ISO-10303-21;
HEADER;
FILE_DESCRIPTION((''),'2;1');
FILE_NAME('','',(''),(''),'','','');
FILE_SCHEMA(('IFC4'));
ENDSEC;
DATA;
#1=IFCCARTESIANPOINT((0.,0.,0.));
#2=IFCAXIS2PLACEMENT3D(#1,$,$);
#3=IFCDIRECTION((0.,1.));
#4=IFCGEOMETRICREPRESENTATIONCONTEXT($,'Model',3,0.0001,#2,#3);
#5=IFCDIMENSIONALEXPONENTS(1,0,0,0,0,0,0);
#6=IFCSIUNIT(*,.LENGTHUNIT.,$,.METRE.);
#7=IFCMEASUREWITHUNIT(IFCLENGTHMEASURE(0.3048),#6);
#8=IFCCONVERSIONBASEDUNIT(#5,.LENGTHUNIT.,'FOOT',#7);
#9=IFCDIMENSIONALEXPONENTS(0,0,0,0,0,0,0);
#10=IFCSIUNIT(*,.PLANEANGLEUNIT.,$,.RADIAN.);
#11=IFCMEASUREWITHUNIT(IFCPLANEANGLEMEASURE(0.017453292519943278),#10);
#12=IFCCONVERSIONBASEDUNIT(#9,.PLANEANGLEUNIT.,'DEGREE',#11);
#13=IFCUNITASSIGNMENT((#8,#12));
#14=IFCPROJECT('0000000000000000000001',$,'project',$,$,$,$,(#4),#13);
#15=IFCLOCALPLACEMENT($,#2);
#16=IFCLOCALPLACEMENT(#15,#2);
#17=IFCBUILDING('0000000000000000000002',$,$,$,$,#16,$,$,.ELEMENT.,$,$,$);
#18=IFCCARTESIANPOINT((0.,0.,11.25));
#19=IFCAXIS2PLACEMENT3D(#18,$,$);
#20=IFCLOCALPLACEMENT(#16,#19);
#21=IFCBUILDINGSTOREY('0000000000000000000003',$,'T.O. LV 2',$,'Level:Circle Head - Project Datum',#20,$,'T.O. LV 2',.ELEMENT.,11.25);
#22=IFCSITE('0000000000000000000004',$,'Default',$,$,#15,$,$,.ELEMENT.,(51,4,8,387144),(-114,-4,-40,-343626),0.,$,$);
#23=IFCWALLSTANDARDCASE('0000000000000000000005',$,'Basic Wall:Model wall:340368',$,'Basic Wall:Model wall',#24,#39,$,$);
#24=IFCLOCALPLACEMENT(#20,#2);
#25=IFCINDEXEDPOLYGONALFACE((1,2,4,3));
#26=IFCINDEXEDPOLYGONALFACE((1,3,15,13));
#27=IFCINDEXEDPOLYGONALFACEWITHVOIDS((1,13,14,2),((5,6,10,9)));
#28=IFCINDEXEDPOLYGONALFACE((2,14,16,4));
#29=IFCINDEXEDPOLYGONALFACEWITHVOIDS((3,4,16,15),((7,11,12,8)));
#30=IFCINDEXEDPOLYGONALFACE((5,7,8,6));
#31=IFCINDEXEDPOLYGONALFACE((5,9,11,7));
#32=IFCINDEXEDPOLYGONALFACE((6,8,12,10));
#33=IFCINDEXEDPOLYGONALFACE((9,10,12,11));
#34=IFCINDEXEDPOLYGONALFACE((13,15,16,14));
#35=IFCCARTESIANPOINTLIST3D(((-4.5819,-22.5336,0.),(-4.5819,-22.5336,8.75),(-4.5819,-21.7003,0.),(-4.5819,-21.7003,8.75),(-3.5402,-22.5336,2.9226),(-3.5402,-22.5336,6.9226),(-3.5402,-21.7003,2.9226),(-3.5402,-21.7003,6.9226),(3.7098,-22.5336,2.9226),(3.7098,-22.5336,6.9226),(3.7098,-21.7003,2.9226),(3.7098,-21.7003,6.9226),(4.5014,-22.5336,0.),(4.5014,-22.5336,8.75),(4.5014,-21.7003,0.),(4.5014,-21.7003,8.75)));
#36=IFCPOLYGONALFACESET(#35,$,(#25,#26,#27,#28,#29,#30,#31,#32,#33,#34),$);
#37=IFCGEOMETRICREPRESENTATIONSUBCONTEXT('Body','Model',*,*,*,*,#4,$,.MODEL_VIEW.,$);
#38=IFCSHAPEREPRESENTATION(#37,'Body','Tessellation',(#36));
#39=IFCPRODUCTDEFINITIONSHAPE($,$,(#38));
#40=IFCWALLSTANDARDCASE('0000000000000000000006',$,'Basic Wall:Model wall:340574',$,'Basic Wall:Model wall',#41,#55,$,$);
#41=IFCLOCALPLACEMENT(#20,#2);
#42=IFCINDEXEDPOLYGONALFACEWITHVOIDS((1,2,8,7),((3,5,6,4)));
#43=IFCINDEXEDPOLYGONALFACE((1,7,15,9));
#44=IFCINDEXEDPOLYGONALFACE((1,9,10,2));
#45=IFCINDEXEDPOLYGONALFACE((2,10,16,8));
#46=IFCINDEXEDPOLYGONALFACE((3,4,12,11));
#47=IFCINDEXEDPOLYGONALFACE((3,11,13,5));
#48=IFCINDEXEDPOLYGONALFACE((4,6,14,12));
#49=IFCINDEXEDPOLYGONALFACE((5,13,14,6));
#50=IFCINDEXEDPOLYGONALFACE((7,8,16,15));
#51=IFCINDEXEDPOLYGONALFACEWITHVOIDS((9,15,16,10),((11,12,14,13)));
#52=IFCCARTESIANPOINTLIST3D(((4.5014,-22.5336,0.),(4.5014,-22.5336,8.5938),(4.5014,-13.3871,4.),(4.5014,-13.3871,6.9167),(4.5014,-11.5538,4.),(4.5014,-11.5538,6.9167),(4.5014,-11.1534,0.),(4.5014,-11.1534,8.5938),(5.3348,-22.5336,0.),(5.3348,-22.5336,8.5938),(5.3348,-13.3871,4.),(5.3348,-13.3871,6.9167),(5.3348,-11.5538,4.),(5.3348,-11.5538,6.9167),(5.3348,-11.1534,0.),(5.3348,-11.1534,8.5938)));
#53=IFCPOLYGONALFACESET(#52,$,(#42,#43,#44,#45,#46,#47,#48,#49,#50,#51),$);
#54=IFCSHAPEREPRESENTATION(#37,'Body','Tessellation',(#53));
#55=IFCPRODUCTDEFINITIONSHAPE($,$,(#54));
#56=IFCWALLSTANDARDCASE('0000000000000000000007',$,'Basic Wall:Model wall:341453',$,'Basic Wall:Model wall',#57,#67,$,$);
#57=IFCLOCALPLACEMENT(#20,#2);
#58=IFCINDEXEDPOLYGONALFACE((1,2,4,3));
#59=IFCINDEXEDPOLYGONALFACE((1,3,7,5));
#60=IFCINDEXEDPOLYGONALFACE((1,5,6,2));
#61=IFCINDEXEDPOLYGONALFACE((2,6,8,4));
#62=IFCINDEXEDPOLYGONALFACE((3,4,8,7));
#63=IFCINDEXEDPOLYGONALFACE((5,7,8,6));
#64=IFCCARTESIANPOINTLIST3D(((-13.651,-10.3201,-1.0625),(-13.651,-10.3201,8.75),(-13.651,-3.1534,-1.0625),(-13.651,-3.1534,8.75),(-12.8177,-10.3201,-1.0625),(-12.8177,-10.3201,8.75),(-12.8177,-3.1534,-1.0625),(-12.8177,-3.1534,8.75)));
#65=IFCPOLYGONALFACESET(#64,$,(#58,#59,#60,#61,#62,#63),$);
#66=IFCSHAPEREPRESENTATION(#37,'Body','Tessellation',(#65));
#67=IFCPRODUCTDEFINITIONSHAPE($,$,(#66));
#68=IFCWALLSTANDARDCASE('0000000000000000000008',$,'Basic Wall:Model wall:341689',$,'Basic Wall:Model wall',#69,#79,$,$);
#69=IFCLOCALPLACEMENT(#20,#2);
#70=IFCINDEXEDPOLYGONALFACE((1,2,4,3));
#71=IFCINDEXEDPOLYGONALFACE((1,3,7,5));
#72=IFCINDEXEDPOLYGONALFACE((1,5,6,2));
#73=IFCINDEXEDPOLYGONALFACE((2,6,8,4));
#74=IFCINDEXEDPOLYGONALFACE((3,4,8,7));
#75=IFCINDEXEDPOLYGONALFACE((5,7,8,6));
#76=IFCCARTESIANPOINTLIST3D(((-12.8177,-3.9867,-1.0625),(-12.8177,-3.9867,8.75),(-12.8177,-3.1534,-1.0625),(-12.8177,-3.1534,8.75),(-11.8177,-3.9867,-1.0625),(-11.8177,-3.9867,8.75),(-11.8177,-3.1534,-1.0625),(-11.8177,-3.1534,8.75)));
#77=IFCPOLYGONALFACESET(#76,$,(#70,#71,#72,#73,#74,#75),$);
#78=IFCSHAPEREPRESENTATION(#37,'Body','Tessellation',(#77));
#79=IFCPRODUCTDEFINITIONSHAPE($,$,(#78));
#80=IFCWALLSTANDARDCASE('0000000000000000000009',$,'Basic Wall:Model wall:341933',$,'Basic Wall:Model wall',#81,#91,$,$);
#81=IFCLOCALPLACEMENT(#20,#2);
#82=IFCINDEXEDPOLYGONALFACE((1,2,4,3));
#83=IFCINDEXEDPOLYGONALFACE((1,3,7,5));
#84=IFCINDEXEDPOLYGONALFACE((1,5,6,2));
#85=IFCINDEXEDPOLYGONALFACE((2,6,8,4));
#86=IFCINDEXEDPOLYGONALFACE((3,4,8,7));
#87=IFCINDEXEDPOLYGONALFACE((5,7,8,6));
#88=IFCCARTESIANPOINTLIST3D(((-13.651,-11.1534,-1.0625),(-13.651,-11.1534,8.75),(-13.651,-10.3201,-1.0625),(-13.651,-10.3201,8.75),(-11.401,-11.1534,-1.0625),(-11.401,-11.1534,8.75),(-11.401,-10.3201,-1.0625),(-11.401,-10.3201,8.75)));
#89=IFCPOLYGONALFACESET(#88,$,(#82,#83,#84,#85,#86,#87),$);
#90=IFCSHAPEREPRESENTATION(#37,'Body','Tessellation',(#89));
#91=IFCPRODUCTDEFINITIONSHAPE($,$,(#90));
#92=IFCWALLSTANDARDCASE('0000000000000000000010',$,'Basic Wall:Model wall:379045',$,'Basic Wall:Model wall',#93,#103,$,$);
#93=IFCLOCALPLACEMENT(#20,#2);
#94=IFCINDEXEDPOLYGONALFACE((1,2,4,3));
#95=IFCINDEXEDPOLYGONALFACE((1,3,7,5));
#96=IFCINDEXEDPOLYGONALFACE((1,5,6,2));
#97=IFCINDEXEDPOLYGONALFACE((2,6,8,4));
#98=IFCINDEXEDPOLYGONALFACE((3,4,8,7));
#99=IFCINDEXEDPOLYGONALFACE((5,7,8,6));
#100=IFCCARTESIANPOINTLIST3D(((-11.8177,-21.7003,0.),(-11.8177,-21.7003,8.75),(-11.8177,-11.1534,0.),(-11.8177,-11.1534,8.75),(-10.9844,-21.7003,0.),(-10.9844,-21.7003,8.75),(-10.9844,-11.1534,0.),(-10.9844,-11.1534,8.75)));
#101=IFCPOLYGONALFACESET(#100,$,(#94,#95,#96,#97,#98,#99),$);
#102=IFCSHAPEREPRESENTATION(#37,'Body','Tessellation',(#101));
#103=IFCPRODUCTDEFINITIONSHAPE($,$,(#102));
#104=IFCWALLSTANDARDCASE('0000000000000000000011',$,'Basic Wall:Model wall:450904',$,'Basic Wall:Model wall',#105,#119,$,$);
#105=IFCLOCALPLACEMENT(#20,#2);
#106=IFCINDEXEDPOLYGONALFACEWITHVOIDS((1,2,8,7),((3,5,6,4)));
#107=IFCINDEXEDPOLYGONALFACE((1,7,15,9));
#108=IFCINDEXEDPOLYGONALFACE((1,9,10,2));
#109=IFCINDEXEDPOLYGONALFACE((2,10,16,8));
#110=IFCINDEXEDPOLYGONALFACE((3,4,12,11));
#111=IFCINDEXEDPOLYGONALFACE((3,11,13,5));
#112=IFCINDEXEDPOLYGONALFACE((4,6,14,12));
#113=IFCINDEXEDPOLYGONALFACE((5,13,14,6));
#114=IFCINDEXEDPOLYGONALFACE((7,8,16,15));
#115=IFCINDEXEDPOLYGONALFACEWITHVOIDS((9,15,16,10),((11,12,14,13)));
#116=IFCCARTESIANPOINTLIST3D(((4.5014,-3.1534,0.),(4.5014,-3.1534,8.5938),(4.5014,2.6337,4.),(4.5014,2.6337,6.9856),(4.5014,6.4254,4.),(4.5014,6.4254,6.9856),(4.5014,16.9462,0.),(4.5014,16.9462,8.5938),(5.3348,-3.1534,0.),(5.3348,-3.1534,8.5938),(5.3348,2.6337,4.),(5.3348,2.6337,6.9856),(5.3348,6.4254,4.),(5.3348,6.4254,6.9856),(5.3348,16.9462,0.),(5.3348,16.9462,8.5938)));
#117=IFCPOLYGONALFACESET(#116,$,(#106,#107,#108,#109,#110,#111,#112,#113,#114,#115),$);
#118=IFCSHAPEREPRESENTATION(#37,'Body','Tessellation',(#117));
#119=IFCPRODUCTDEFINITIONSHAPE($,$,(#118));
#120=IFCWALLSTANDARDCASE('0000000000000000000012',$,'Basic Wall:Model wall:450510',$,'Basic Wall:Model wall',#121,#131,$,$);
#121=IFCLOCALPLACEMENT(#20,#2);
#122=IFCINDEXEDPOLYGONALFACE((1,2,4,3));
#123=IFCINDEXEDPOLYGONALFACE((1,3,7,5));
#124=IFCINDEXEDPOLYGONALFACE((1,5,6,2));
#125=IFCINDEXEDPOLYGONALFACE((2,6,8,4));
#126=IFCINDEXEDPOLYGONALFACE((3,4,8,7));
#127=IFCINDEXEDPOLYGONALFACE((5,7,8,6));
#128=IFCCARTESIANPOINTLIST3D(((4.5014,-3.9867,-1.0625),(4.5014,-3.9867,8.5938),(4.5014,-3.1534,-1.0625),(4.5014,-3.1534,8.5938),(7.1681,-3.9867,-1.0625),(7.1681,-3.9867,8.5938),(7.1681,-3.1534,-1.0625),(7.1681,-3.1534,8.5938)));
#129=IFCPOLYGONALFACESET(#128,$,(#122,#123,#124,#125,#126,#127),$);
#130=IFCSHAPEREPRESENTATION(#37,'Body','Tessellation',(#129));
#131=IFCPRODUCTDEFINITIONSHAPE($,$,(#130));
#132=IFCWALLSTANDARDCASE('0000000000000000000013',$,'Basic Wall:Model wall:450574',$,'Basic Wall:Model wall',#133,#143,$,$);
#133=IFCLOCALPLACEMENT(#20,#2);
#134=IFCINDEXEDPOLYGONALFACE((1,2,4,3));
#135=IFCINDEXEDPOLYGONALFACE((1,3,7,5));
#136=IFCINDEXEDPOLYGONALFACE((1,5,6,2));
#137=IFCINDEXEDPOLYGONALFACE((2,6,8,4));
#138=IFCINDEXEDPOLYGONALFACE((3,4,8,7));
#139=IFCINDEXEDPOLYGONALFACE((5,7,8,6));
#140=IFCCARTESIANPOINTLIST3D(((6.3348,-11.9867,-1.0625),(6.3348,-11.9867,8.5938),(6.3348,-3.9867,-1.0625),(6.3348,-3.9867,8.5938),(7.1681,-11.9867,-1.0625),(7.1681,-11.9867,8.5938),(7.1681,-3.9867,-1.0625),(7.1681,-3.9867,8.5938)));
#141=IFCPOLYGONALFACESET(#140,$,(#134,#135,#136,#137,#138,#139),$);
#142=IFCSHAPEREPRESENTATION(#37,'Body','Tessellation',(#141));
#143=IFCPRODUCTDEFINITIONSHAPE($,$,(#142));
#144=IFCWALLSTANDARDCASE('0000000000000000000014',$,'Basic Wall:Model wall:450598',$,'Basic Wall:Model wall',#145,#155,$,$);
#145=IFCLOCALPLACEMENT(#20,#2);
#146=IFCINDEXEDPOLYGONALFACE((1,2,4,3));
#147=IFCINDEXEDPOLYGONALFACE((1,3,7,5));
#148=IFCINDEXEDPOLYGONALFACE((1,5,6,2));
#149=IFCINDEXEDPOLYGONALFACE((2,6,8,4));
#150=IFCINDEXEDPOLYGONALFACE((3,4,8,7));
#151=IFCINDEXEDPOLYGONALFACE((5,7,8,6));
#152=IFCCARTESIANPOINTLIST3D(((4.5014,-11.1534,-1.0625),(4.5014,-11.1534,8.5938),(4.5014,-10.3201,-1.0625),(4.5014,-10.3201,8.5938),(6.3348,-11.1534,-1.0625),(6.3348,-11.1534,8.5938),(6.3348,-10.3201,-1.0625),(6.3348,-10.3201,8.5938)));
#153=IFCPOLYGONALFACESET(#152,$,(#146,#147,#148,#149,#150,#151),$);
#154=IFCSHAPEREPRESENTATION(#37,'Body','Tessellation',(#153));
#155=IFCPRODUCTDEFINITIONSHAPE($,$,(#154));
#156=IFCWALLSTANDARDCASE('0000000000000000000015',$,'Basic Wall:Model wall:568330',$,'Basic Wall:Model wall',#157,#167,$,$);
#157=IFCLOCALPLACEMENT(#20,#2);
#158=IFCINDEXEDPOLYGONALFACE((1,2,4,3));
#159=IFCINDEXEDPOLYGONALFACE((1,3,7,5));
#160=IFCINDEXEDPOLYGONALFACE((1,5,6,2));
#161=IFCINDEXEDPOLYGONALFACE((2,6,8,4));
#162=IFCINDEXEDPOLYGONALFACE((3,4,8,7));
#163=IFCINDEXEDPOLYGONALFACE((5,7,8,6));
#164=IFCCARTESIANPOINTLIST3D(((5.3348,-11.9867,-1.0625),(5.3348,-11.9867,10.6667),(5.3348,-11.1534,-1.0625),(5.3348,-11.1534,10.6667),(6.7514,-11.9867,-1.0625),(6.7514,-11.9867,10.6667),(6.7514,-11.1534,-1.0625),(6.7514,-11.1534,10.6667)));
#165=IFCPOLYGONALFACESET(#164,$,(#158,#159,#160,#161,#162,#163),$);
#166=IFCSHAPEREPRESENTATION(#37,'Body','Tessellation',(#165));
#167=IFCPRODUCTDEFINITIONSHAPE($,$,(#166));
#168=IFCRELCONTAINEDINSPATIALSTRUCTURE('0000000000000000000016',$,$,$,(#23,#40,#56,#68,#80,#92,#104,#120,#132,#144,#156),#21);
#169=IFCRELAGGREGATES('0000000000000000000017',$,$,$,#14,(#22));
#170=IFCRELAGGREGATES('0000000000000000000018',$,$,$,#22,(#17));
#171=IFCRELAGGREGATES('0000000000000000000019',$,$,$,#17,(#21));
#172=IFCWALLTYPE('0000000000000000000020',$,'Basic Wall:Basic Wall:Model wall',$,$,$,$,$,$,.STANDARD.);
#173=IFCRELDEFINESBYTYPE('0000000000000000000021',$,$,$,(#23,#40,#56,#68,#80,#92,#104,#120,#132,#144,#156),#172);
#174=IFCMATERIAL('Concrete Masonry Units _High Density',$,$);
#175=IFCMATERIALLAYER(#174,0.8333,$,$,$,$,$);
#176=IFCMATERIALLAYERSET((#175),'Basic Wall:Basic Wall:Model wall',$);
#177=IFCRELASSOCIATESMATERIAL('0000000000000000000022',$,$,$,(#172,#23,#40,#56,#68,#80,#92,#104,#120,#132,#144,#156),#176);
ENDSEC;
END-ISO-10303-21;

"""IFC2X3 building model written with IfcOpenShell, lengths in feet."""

from ifc_helpers import new_model, entity, si_unit, converted_unit, direction, frame, frame_2d, origin, place, context, subcontext, project, spatial, rectangle, extrude, material, layer, layer_set, layer_usage, type_object, element, save


model = new_model("IFC2X3")

# Units and contexts
model_context = context("Model", 3, precision=0.0001, world=origin(), true_north=direction((0.0, 1.0)))
body_context = subcontext(model_context, "Body", "Model", "MODEL_VIEW")
ifc_project = project(units=[converted_unit("LENGTHUNIT", "FOOT", entity("IfcLengthMeasure", 0.3048), si_unit("LENGTHUNIT", "METRE"), dimensions=[1, 0, 0, 0, 0, 0, 0]), converted_unit("PLANEANGLEUNIT", "DEGREE", entity("IfcPlaneAngleMeasure", 0.017453292519943278), si_unit("PLANEANGLEUNIT", "RADIAN"), dimensions=[0, 0, 0, 0, 0, 0, 0])], contexts=[model_context])

# Site, building, storey
site_placement = place(None, origin())
site = spatial("IfcSite", under=ifc_project, at=site_placement, Name="Default", CompositionType="ELEMENT", RefLatitude=(51, 4, 8, 387144), RefLongitude=(-114, -4, -40, -343626), RefElevation=0.0)
building_placement = place(site_placement, origin())
building = spatial("IfcBuilding", under=site, at=building_placement, CompositionType="ELEMENT")
storey_placement = place(building_placement, frame((0.0, 0.0, 11.25)))
storey = spatial("IfcBuildingStorey", under=building, at=storey_placement, Name="T.O. LV 2", ObjectType="Level:Circle Head - Project Datum", LongName="T.O. LV 2", CompositionType="ELEMENT", Elevation=11.25)

# Walls, openings
ifc_material_1 = material(Name="Concrete Masonry Units _High Density")
ifc_layer_1 = layer(ifc_material_1, 0.8333)
ifc_layer_set_1 = layer_set([ifc_layer_1], Name="Basic Wall:Basic Wall:Model wall")
ifc_layer_usage_1 = layer_usage(ifc_layer_set_1, "AXIS2", "NEGATIVE", 0.4167)
wall_type_1 = type_object("IfcWallType", Name="Basic Wall:Basic Wall:Model wall", PredefinedType="STANDARD", material=ifc_layer_set_1)
wall_1_placement = place(storey_placement, frame((4.5014, -22.117, 0.0), z_axis=(0.0, 0.0, 1.0), x_axis=(-1.0, 0.0, 0.0)))
wall_1 = element("IfcWallStandardCase", 1, at=wall_1_placement, inside=storey, type_object=wall_type_1, material=ifc_layer_usage_1, Name="Basic Wall:Model wall:340368", ObjectType="Basic Wall:Model wall", context=body_context, shape_type="SweptSolid", body=[
    extrude(rectangle(XDim=9.0833, YDim=0.8333, at=frame_2d((4.5417, 0.0), x_axis=(-1.0, 0.0))), origin(), (0.0, 0.0, 1.0), 8.75),
])
opening_1_placement = place(wall_1_placement, frame((4.5014, -22.117, 0.0), z_axis=(0.0, 0.0, 1.0), x_axis=(-1.0, 0.0, 0.0)))
element("IfcOpeningElement", 2, at=opening_1_placement, cuts=wall_1, ObjectType="Opening", context=body_context, shape_type="SweptSolid", body=[
    extrude(rectangle(XDim=4.0, YDim=7.25, at=frame_2d((0.0, 0.0), x_axis=(0.0, 1.0))), frame((0.0848, -21.692, 4.9226), z_axis=(0.0, -1.0, 0.0), x_axis=(1.0, 0.0, 0.0)), (0.0, 0.0, 1.0), 0.85),
])
ifc_layer_usage_2 = layer_usage(ifc_layer_set_1, "AXIS2", "NEGATIVE", 0.4167)
wall_2_placement = place(storey_placement, frame((4.9181, -22.5336, 0.0), z_axis=(0.0, 0.0, 1.0), x_axis=(0.0, 1.0, 0.0)))
wall_2 = element("IfcWallStandardCase", 3, at=wall_2_placement, inside=storey, type_object=wall_type_1, material=ifc_layer_usage_2, Name="Basic Wall:Model wall:340574", ObjectType="Basic Wall:Model wall", context=body_context, shape_type="SweptSolid", body=[
    extrude(rectangle(XDim=11.3802, YDim=0.8333, at=frame_2d((5.6901, 0.0), x_axis=(-1.0, 0.0))), origin(), (0.0, 0.0, 1.0), 8.5938),
])
opening_2_placement = place(wall_2_placement, frame((22.5336, 4.9181, 0.0), z_axis=(0.0, 0.0, 1.0), x_axis=(0.0, -1.0, 0.0)))
element("IfcOpeningElement", 4, at=opening_2_placement, cuts=wall_2, ObjectType="Opening", context=body_context, shape_type="SweptSolid", body=[
    extrude(rectangle(XDim=2.9167, YDim=1.8333, at=frame_2d((0.0, 0.0), x_axis=(1.0, 0.0))), frame((5.3431, -12.4705, 5.4583), z_axis=(-1.0, 0.0, 0.0), x_axis=(0.0, 0.0, 1.0)), (0.0, 0.0, 1.0), 0.85),
])

# Walls
ifc_layer_usage_3 = layer_usage(ifc_layer_set_1, "AXIS2", "NEGATIVE", 0.4167)
wall_3_placement = place(storey_placement, frame((-13.2344, -3.1534, -1.0625), z_axis=(0.0, 0.0, 1.0), x_axis=(0.0, -1.0, 0.0)))
element("IfcWallStandardCase", 5, at=wall_3_placement, inside=storey, type_object=wall_type_1, material=ifc_layer_usage_3, Name="Basic Wall:Model wall:341453", ObjectType="Basic Wall:Model wall", context=body_context, shape_type="SweptSolid", body=[
    extrude(rectangle(XDim=7.1667, YDim=0.8333, at=frame_2d((3.5833, 0.0), x_axis=(-1.0, 0.0))), origin(), (0.0, 0.0, 1.0), 9.8125),
])
ifc_layer_usage_4 = layer_usage(ifc_layer_set_1, "AXIS2", "NEGATIVE", 0.4167)
wall_4_placement = place(storey_placement, frame((-12.8177, -3.5701, -1.0625)))
element("IfcWallStandardCase", 6, at=wall_4_placement, inside=storey, type_object=wall_type_1, material=ifc_layer_usage_4, Name="Basic Wall:Model wall:341689", ObjectType="Basic Wall:Model wall", context=body_context, shape_type="SweptSolid", body=[
    extrude(rectangle(XDim=1.0, YDim=0.8333, at=frame_2d((0.5, 0.0), x_axis=(-1.0, 0.0))), origin(), (0.0, 0.0, 1.0), 9.8125),
])
ifc_layer_usage_5 = layer_usage(ifc_layer_set_1, "AXIS2", "NEGATIVE", 0.4167)
wall_5_placement = place(storey_placement, frame((-13.651, -10.7367, -1.0625)))
element("IfcWallStandardCase", 7, at=wall_5_placement, inside=storey, type_object=wall_type_1, material=ifc_layer_usage_5, Name="Basic Wall:Model wall:341933", ObjectType="Basic Wall:Model wall", context=body_context, shape_type="SweptSolid", body=[
    extrude(rectangle(XDim=2.25, YDim=0.8333, at=frame_2d((1.125, 0.0), x_axis=(-1.0, 0.0))), origin(), (0.0, 0.0, 1.0), 9.8125),
])
ifc_layer_usage_6 = layer_usage(ifc_layer_set_1, "AXIS2", "NEGATIVE", 0.4167)
wall_6_placement = place(storey_placement, frame((-11.401, -11.1534, 0.0), z_axis=(0.0, 0.0, 1.0), x_axis=(0.0, -1.0, 0.0)))
element("IfcWallStandardCase", 8, at=wall_6_placement, inside=storey, type_object=wall_type_1, material=ifc_layer_usage_6, Name="Basic Wall:Model wall:379045", ObjectType="Basic Wall:Model wall", context=body_context, shape_type="SweptSolid", body=[
    extrude(rectangle(XDim=10.5469, YDim=0.8333, at=frame_2d((5.2734, 0.0), x_axis=(-1.0, 0.0))), origin(), (0.0, 0.0, 1.0), 8.75),
])

# Wall, opening
ifc_layer_usage_7 = layer_usage(ifc_layer_set_1, "AXIS2", "NEGATIVE", 0.4167)
wall_7_placement = place(storey_placement, frame((4.9181, -3.1534, 0.0), z_axis=(0.0, 0.0, 1.0), x_axis=(0.0, 1.0, 0.0)))
wall_7 = element("IfcWallStandardCase", 9, at=wall_7_placement, inside=storey, type_object=wall_type_1, material=ifc_layer_usage_7, Name="Basic Wall:Model wall:450904", ObjectType="Basic Wall:Model wall", context=body_context, shape_type="SweptSolid", body=[
    extrude(rectangle(XDim=20.0996, YDim=0.8333, at=frame_2d((10.0498, 0.0), x_axis=(-1.0, 0.0))), origin(), (0.0, 0.0, 1.0), 8.5938),
])
opening_3_placement = place(wall_7_placement, frame((3.1534, 4.9181, 0.0), z_axis=(0.0, 0.0, 1.0), x_axis=(0.0, -1.0, 0.0)))
element("IfcOpeningElement", 10, at=opening_3_placement, cuts=wall_7, ObjectType="Opening", context=body_context, shape_type="SweptSolid", body=[
    extrude(rectangle(XDim=2.9856, YDim=3.7917, at=frame_2d((0.0, 0.0), x_axis=(1.0, 0.0))), frame((5.3431, 4.5295, 5.4928), z_axis=(-1.0, 0.0, 0.0), x_axis=(0.0, 0.0, 1.0)), (0.0, 0.0, 1.0), 0.85),
])

# Walls
ifc_layer_usage_8 = layer_usage(ifc_layer_set_1, "AXIS2", "NEGATIVE", 0.4167)
wall_8_placement = place(storey_placement, frame((4.5014, -3.5701, -1.0625)))
element("IfcWallStandardCase", 11, at=wall_8_placement, inside=storey, type_object=wall_type_1, material=ifc_layer_usage_8, Name="Basic Wall:Model wall:450510", ObjectType="Basic Wall:Model wall", context=body_context, shape_type="SweptSolid", body=[
    extrude(rectangle(XDim=2.6667, YDim=0.8333, at=frame_2d((1.3333, 0.0), x_axis=(-1.0, 0.0))), origin(), (0.0, 0.0, 1.0), 9.6563),
])
ifc_layer_usage_9 = layer_usage(ifc_layer_set_1, "AXIS2", "NEGATIVE", 0.4167)
wall_9_placement = place(storey_placement, frame((6.7514, -3.9867, -1.0625), z_axis=(0.0, 0.0, 1.0), x_axis=(0.0, -1.0, 0.0)))
element("IfcWallStandardCase", 12, at=wall_9_placement, inside=storey, type_object=wall_type_1, material=ifc_layer_usage_9, Name="Basic Wall:Model wall:450574", ObjectType="Basic Wall:Model wall", context=body_context, shape_type="SweptSolid", body=[
    extrude(rectangle(XDim=8.0, YDim=0.8333, at=frame_2d((4.0, 0.0), x_axis=(-1.0, 0.0))), origin(), (0.0, 0.0, 1.0), 9.6563),
])
ifc_layer_usage_10 = layer_usage(ifc_layer_set_1, "AXIS2", "NEGATIVE", 0.4167)
wall_10_placement = place(storey_placement, frame((6.3348, -10.7367, -1.0625), z_axis=(0.0, 0.0, 1.0), x_axis=(-1.0, 0.0, 0.0)))
element("IfcWallStandardCase", 13, at=wall_10_placement, inside=storey, type_object=wall_type_1, material=ifc_layer_usage_10, Name="Basic Wall:Model wall:450598", ObjectType="Basic Wall:Model wall", context=body_context, shape_type="SweptSolid", body=[
    extrude(rectangle(XDim=1.8333, YDim=0.8333, at=frame_2d((0.9167, 0.0), x_axis=(-1.0, 0.0))), origin(), (0.0, 0.0, 1.0), 9.6563),
])
ifc_layer_usage_11 = layer_usage(ifc_layer_set_1, "AXIS2", "NEGATIVE", 0.4167)
wall_11_placement = place(storey_placement, frame((6.7514, -11.5701, -1.0625), z_axis=(0.0, 0.0, 1.0), x_axis=(-1.0, 0.0, 0.0)))
element("IfcWallStandardCase", 14, at=wall_11_placement, inside=storey, type_object=wall_type_1, material=ifc_layer_usage_11, Name="Basic Wall:Model wall:568330", ObjectType="Basic Wall:Model wall", context=body_context, shape_type="SweptSolid", body=[
    extrude(rectangle(XDim=1.4167, YDim=0.8333, at=frame_2d((0.7083, 0.0), x_axis=(-1.0, 0.0))), origin(), (0.0, 0.0, 1.0), 11.7292),
])

save(model, "model.ifc")
